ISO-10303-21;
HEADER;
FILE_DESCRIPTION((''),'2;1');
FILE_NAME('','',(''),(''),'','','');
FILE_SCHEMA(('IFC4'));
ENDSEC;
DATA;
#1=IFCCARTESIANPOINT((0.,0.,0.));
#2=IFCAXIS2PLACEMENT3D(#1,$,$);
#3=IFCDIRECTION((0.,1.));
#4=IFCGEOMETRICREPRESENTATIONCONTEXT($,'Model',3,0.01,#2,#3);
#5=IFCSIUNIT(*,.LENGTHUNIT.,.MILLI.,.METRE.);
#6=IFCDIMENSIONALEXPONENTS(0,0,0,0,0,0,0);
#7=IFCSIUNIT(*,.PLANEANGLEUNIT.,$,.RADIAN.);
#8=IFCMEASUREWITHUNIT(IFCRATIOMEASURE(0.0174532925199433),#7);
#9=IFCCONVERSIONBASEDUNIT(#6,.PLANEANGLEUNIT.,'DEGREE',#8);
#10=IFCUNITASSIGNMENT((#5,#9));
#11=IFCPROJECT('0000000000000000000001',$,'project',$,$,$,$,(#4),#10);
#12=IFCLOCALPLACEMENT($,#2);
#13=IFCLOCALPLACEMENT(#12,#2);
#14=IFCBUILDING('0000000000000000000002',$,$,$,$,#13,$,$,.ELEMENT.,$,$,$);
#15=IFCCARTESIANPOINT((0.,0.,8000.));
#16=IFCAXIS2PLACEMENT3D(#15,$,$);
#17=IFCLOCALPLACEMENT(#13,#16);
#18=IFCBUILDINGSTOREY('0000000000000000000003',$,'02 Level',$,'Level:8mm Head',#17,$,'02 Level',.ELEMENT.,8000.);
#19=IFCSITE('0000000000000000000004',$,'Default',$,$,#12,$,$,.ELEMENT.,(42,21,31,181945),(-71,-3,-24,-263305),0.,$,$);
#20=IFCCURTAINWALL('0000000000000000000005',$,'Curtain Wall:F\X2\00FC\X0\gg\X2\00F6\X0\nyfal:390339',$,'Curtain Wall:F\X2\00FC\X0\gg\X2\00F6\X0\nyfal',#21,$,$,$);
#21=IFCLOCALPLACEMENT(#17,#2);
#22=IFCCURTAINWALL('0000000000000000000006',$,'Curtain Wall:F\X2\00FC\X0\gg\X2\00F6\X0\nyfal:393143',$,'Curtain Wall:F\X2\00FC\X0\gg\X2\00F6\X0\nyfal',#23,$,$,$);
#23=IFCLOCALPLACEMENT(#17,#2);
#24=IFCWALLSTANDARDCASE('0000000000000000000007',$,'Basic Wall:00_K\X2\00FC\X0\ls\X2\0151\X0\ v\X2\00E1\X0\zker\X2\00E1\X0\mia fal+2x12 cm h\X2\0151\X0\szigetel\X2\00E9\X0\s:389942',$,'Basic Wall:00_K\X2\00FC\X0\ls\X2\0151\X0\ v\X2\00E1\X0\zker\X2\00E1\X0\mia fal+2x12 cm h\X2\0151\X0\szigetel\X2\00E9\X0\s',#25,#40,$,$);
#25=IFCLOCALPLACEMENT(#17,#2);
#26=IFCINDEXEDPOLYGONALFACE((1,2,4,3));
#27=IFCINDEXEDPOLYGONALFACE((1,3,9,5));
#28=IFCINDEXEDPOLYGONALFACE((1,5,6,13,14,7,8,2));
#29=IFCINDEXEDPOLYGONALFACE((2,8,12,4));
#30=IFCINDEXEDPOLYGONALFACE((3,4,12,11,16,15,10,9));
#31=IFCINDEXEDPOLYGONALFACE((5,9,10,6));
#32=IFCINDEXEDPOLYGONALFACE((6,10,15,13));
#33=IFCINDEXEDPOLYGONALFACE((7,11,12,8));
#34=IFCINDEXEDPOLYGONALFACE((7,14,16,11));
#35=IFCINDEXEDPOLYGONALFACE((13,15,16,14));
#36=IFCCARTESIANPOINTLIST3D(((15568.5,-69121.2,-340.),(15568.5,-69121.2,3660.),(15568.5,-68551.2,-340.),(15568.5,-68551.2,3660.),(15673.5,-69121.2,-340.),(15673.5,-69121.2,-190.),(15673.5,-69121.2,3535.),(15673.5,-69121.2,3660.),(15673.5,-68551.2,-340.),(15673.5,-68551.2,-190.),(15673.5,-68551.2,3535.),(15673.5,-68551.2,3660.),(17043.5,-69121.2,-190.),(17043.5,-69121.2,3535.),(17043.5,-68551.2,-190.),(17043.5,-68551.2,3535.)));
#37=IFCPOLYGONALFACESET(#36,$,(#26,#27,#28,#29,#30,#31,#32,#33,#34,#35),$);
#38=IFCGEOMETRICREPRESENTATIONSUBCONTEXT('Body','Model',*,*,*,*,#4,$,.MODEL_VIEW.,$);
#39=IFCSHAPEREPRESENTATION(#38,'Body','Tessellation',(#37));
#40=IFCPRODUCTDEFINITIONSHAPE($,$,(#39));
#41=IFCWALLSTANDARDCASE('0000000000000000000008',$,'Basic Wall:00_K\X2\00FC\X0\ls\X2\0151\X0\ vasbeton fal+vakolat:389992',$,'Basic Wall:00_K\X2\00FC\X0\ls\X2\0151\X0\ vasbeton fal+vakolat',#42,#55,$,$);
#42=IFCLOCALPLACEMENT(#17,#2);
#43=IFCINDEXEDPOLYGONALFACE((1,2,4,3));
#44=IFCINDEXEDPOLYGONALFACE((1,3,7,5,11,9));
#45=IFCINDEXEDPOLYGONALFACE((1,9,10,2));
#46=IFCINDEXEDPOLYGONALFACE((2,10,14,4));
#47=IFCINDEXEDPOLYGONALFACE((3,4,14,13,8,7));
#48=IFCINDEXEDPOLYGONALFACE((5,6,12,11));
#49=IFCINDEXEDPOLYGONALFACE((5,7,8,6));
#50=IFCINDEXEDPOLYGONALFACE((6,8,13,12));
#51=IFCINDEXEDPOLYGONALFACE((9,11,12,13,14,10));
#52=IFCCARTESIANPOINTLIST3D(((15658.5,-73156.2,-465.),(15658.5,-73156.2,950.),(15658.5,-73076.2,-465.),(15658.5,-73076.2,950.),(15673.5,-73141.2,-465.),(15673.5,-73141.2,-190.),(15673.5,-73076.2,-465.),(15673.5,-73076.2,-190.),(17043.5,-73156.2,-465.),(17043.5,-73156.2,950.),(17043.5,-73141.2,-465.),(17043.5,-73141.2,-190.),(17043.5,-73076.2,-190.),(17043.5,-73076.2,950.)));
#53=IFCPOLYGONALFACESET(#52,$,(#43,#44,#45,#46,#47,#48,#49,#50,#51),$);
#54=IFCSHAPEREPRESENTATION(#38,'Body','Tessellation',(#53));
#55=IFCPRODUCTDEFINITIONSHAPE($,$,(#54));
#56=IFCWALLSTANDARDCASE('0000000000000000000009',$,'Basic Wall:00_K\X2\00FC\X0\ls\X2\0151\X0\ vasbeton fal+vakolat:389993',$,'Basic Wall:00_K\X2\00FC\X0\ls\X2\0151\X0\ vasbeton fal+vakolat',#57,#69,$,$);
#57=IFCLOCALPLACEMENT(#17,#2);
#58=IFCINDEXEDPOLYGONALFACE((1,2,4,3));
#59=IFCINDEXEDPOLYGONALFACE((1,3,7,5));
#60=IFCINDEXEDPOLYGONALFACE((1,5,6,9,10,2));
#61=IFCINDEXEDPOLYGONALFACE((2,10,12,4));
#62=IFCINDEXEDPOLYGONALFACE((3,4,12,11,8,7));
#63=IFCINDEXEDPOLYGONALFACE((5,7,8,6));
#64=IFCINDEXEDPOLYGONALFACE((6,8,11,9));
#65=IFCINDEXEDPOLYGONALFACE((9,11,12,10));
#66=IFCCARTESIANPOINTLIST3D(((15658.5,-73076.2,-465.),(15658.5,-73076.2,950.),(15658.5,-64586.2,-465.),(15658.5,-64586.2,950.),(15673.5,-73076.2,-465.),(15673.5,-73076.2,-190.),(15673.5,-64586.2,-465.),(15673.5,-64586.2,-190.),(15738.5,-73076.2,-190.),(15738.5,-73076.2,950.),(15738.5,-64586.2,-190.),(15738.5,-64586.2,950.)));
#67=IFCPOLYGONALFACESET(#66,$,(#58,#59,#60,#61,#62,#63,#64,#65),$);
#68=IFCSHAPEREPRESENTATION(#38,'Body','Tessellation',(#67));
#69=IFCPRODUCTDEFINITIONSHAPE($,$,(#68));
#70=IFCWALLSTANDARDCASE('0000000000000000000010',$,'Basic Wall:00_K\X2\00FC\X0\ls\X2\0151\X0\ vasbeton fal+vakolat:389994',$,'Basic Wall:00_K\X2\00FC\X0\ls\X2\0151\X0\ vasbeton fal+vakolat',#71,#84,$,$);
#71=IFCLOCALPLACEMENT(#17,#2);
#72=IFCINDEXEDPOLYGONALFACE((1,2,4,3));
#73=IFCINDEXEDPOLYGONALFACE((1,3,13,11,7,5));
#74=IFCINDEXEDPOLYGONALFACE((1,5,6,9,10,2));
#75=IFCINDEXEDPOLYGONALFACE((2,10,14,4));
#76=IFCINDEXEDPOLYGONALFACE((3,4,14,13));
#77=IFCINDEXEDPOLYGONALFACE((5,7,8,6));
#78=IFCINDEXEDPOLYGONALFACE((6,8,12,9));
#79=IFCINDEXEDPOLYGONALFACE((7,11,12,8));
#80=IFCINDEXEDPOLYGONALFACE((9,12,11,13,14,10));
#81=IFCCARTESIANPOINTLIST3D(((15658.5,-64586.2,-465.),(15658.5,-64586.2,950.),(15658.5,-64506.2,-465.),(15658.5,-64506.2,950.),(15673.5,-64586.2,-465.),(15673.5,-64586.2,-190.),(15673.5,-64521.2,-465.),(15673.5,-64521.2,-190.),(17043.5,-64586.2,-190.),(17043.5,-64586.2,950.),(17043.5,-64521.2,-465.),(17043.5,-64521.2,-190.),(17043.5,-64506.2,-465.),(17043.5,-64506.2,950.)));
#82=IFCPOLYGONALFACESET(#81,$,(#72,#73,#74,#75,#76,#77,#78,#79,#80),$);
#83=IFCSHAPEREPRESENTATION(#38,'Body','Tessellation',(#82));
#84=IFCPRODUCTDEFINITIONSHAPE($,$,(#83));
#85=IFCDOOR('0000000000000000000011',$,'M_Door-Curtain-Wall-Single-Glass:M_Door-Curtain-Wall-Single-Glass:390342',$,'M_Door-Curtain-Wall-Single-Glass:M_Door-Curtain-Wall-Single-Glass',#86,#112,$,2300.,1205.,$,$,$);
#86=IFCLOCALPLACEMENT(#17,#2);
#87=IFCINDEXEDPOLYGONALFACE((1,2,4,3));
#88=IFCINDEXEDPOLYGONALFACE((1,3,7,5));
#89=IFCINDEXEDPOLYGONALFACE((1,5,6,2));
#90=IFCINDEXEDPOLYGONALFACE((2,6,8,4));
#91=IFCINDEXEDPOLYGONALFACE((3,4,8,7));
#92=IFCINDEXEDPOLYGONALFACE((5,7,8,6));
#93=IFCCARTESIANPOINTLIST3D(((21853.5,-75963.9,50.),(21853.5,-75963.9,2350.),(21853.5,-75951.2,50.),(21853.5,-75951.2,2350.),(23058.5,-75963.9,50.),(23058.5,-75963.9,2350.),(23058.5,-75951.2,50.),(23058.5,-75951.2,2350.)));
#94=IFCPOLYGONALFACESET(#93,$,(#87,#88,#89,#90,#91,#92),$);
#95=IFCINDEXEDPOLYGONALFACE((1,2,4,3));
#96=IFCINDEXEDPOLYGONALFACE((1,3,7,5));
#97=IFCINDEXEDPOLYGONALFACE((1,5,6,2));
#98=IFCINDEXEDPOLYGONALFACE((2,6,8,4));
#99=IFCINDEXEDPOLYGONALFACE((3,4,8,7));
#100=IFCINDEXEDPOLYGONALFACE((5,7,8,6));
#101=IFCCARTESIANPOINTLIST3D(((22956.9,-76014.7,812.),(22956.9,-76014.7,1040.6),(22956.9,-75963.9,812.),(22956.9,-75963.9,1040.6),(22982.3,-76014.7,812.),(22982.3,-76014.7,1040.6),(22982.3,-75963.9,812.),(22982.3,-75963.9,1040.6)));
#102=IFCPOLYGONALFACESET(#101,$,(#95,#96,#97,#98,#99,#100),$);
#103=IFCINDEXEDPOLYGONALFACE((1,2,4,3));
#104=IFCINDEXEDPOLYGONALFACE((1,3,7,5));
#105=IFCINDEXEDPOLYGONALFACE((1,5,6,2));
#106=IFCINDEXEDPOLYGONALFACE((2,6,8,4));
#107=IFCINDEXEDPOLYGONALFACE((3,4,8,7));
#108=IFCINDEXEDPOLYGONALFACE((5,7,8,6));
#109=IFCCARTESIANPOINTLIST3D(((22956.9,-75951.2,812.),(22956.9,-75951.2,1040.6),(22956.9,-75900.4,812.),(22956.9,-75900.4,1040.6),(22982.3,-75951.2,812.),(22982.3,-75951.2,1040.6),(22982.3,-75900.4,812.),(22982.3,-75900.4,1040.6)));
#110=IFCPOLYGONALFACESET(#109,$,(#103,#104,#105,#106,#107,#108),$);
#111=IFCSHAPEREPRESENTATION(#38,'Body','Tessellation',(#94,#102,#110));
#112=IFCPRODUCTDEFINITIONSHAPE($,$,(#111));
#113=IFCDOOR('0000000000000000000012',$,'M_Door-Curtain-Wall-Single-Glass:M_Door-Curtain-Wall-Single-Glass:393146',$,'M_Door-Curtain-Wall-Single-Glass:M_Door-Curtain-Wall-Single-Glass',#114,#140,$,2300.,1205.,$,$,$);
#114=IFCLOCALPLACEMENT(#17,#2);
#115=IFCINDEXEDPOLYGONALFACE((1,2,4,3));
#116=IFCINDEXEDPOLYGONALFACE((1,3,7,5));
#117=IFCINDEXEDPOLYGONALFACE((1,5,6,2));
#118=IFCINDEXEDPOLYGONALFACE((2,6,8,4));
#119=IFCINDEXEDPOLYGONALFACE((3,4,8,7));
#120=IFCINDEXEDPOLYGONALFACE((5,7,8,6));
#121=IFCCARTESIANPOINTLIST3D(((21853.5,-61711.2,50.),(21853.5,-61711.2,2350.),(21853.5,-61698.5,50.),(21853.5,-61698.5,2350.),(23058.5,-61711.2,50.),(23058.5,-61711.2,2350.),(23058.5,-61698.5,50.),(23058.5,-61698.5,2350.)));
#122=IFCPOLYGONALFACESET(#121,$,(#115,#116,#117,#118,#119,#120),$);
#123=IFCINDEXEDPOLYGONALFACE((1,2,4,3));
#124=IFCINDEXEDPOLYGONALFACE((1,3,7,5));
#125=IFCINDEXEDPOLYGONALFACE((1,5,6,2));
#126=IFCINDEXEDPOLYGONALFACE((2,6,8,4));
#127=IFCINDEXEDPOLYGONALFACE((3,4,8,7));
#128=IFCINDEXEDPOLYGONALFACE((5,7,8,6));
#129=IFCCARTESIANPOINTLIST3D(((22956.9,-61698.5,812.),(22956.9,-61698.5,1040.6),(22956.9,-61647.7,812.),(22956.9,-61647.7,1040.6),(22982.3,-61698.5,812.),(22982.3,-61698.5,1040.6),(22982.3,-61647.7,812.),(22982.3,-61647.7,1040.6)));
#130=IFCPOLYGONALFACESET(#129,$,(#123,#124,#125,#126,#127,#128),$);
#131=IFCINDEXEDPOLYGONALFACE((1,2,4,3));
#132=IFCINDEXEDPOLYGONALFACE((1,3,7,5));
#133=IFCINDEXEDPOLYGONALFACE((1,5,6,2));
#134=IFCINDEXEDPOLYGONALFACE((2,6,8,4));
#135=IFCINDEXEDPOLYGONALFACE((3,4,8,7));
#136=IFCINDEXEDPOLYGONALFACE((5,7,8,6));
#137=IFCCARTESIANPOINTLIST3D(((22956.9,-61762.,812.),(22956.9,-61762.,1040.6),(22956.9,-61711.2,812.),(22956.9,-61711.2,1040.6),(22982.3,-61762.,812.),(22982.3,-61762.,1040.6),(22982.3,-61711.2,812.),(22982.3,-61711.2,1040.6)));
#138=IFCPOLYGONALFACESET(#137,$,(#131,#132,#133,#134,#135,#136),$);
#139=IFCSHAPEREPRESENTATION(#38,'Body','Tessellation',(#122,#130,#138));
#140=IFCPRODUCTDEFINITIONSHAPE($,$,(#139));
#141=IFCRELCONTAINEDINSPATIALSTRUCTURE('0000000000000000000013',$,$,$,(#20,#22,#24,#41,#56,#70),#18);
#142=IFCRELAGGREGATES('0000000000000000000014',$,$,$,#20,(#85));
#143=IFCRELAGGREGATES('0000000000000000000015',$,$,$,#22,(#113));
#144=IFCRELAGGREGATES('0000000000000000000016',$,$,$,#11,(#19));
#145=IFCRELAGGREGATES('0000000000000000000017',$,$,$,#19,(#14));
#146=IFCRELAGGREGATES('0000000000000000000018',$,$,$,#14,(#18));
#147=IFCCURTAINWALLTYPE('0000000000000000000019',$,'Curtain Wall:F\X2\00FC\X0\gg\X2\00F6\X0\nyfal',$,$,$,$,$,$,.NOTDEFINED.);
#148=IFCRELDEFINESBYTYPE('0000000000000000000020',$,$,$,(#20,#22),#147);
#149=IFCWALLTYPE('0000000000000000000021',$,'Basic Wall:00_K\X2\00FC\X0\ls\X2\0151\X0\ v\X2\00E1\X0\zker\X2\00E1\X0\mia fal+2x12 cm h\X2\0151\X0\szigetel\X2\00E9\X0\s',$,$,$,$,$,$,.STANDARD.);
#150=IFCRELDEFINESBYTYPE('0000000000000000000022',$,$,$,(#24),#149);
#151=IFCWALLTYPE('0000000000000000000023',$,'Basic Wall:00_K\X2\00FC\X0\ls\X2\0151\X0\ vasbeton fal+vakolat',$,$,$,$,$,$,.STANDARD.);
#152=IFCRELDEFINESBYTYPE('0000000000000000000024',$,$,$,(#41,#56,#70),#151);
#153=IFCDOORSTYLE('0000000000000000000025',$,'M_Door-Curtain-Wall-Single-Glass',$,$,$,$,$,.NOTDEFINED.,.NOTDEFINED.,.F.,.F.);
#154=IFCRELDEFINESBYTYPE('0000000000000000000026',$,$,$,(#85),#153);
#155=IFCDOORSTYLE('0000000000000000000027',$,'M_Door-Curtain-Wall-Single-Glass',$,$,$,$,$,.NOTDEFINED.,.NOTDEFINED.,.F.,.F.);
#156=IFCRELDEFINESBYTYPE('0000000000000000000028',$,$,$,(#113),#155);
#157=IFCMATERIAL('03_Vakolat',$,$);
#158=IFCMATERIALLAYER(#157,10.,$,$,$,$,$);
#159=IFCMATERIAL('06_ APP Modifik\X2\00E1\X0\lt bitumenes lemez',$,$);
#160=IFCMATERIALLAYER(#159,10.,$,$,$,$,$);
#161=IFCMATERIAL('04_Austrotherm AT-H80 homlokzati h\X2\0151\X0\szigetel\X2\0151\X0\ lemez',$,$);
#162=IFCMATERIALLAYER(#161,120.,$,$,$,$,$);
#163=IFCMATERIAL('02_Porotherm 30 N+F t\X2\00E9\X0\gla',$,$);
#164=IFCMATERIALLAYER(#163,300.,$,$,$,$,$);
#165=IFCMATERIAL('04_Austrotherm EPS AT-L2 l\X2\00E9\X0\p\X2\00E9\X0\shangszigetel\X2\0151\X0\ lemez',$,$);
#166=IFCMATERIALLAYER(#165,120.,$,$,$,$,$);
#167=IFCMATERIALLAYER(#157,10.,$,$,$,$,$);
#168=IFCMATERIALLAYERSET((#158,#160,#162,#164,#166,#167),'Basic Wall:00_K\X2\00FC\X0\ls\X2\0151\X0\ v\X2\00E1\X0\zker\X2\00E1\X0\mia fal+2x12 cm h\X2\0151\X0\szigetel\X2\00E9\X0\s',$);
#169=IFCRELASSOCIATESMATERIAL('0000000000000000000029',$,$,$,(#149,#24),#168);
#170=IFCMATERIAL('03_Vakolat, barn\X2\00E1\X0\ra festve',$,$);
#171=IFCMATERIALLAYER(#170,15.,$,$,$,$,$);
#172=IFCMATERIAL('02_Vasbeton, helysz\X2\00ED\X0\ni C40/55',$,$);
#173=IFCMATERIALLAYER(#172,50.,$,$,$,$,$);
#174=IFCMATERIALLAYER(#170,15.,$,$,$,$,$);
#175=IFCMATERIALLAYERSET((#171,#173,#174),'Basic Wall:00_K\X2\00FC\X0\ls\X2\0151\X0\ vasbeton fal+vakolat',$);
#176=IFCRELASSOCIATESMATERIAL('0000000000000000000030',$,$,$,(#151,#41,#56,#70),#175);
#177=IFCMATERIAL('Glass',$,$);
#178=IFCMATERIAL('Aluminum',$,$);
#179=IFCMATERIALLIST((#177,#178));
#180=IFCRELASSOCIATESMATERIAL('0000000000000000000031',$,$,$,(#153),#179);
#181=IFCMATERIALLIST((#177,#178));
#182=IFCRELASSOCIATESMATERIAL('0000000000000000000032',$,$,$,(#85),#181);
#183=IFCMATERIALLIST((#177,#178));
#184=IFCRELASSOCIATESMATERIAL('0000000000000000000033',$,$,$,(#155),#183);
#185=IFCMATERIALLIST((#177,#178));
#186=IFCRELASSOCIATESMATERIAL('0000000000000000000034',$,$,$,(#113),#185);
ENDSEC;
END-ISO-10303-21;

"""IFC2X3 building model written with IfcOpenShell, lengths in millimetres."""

from ifc_helpers import new_model, entity, si_unit, converted_unit, direction, frame, frame_2d, origin, origin_2d_with_axis, place, context, subcontext, project, spatial, polyline, rectangle, extrude, clip, bounded_halfspace, source, transform, mapped, material, material_list, layer, layer_set, layer_usage, type_object, type_shapes, element, aggregate, save


model = new_model("IFC2X3")

# Units and contexts
model_context = context("Model", 3, precision=0.01, world=origin(), true_north=direction((0.0, 1.0)))
body_context = subcontext(model_context, "Body", "Model", "MODEL_VIEW")
ifc_project = project(units=[si_unit("LENGTHUNIT", "METRE", prefix="MILLI"), converted_unit("PLANEANGLEUNIT", "DEGREE", entity("IfcRatioMeasure", 0.0174532925199433), si_unit("PLANEANGLEUNIT", "RADIAN"), dimensions=[0, 0, 0, 0, 0, 0, 0])], contexts=[model_context])

# Site, building, storey
site_placement = place(None, origin())
site = spatial("IfcSite", under=ifc_project, at=site_placement, Name="Default", CompositionType="ELEMENT", RefLatitude=(42, 21, 31, 181945), RefLongitude=(-71, -3, -24, -263305), RefElevation=0.0)
building_placement = place(site_placement, origin())
building = spatial("IfcBuilding", under=site, at=building_placement, CompositionType="ELEMENT")
storey_placement = place(building_placement, frame((0.0, 0.0, 8000.0)))
storey = spatial("IfcBuildingStorey", under=building, at=storey_placement, Name="02 Level", ObjectType="Level:8mm Head", LongName="02 Level", CompositionType="ELEMENT", Elevation=8000.0)

# Curtain walls
curtain_wall_type = type_object("IfcCurtainWallType", Name="Curtain Wall:Függönyfal", PredefinedType="NOTDEFINED")
curtain_wall_1_placement = place(storey_placement, frame((0.0, 0.0, -8000.0)))
curtain_wall_1 = element("IfcCurtainWall", 1, at=curtain_wall_1_placement, inside=storey, type_object=curtain_wall_type, Name="Curtain Wall:Függönyfal:390339", ObjectType="Curtain Wall:Függönyfal")
curtain_wall_2_placement = place(storey_placement, frame((0.0, 0.0, -8000.0)))
curtain_wall_2 = element("IfcCurtainWall", 2, at=curtain_wall_2_placement, inside=storey, type_object=curtain_wall_type, Name="Curtain Wall:Függönyfal:393143", ObjectType="Curtain Wall:Függönyfal")

# Shared definitions
ifc_material_1 = material(Name="03_Vakolat")
ifc_material_2 = material(Name="04_Austrotherm AT-H80 homlokzati hőszigetelő lemez")
ifc_material_3 = material(Name="02_Porotherm 30 N+F tégla")

# Walls
ifc_layer_1 = layer(ifc_material_1, 10.0)
ifc_material_4 = material(Name="06_ APP Modifikált bitumenes lemez")
ifc_layer_2 = layer(ifc_material_4, 10.0)
ifc_layer_3 = layer(ifc_material_2, 120.0)
ifc_layer_4 = layer(ifc_material_3, 300.0)
ifc_material_5 = material(Name="04_Austrotherm EPS AT-L2 lépéshangszigetelő lemez")
ifc_layer_5 = layer(ifc_material_5, 120.0)
ifc_layer_6 = layer(ifc_material_1, 10.0)
ifc_layer_set_1 = layer_set([ifc_layer_1, ifc_layer_2, ifc_layer_3, ifc_layer_4, ifc_layer_5, ifc_layer_6], Name="Basic Wall:00_Külső vázkerámia fal+2x12 cm hőszigetelés")
ifc_layer_usage_1 = layer_usage(ifc_layer_set_1, "AXIS2", "NEGATIVE", 285.0)
wall_type_1 = type_object("IfcWallType", Name="Basic Wall:00_Külső vázkerámia fal+2x12 cm hőszigetelés", PredefinedType="STANDARD", material=ifc_layer_set_1)
wall_1_placement = place(storey_placement, frame((17043.5, -68836.2, -340.0), z_axis=(0.0, 0.0, 1.0), x_axis=(-1.0, 0.0, 0.0)))
element("IfcWallStandardCase", 3, at=wall_1_placement, inside=storey, type_object=wall_type_1, material=ifc_layer_usage_1, Name="Basic Wall:00_Külső vázkerámia fal+2x12 cm hőszigetelés:389942", ObjectType="Basic Wall:00_Külső vázkerámia fal+2x12 cm hőszigetelés", context=body_context, shape_type="Clipping", body=[
    clip(clip(clip(clip(extrude(rectangle(XDim=1475.0, YDim=570.0, at=frame_2d((737.5, 0.0), x_axis=(-1.0, 0.0))), origin(), (0.0, 0.0, 1.0), 4000.0), bounded_halfspace(frame((1370.0, 285.0, 150.0)), True, frame((1370.0, 285.0, 150.0)), polyline([(0.0, 0.0), (-1370.0, 0.0), (-1370.0, -570.0), (0.0, -570.0), (0.0, 0.0)]))), bounded_halfspace(frame((1370.0, -285.0, 150.0), z_axis=(1.0, 0.0, 0.0), x_axis=(0.0, 0.0, 1.0)), True, frame((1370.0, -285.0, 150.0), z_axis=(1.0, 0.0, 0.0), x_axis=(0.0, 0.0, 1.0)), polyline([(0.0, 0.0), (-150.0, 0.0), (-150.0, -570.0), (0.0, -570.0), (0.0, 0.0)]))), bounded_halfspace(frame((1370.0, -285.0, 3875.0), z_axis=(0.0, 0.0, -1.0), x_axis=(-1.0, 0.0, 0.0)), True, frame((1370.0, -285.0, 3875.0), z_axis=(0.0, 0.0, -1.0), x_axis=(-1.0, 0.0, 0.0)), polyline([(0.0, 0.0), (1370.0, 0.0), (1370.0, 570.0), (0.0, 570.0), (0.0, 0.0)]))), bounded_halfspace(frame((1370.0, 285.0, 3875.0), z_axis=(1.0, 0.0, 0.0), x_axis=(0.0, 0.0, 1.0)), True, frame((1370.0, 285.0, 3875.0), z_axis=(1.0, 0.0, 0.0), x_axis=(0.0, 0.0, 1.0)), polyline([(0.0, 0.0), (125.0, 0.0), (125.0, 570.0), (0.0, 570.0), (0.0, 0.0)]))),
])
ifc_material_6 = material(Name="03_Vakolat, barnára festve")
ifc_layer_7 = layer(ifc_material_6, 15.0)
ifc_material_7 = material(Name="02_Vasbeton, helyszíni C40/55")
ifc_layer_8 = layer(ifc_material_7, 50.0)
ifc_layer_9 = layer(ifc_material_6, 15.0)
ifc_layer_set_2 = layer_set([ifc_layer_7, ifc_layer_8, ifc_layer_9], Name="Basic Wall:00_Külső vasbeton fal+vakolat")
ifc_layer_usage_2 = layer_usage(ifc_layer_set_2, "AXIS2", "NEGATIVE", 40.0)
wall_type_2 = type_object("IfcWallType", Name="Basic Wall:00_Külső vasbeton fal+vakolat", PredefinedType="STANDARD", material=ifc_layer_set_2)
wall_2_placement = place(storey_placement, frame((17043.5, -73116.2, -465.0), z_axis=(0.0, 0.0, 1.0), x_axis=(-1.0, 0.0, 0.0)))
element("IfcWallStandardCase", 4, at=wall_2_placement, inside=storey, type_object=wall_type_2, material=ifc_layer_usage_2, Name="Basic Wall:00_Külső vasbeton fal+vakolat:389992", ObjectType="Basic Wall:00_Külső vasbeton fal+vakolat", context=body_context, shape_type="Clipping", body=[
    clip(clip(clip(extrude(rectangle(XDim=1385.0, YDim=80.0, at=frame_2d((692.5, 0.0), x_axis=(-1.0, 0.0))), origin(), (0.0, 0.0, 1.0), 1415.0), bounded_halfspace(frame((1370.0, 25.0, 0.0), z_axis=(1.0, 0.0, 0.0), x_axis=(0.0, 0.0, 1.0)), True, frame((1370.0, 25.0, 0.0), z_axis=(1.0, 0.0, 0.0), x_axis=(0.0, 0.0, 1.0)), polyline([(0.0, 0.0), (125.0, 0.0), (275.0, 0.0), (275.0, 65.0), (0.0, 65.0), (0.0, 0.0)]))), bounded_halfspace(frame((1370.0, 25.0, 0.0), z_axis=(0.0, 1.0, 0.0), x_axis=(0.0, 0.0, 1.0)), True, frame((1370.0, 25.0, 0.0), z_axis=(0.0, 1.0, 0.0), x_axis=(0.0, 0.0, 1.0)), polyline([(0.0, 0.0), (0.0, -1370.0), (125.0, -1370.0), (275.0, -1370.0), (275.0, 0.0), (125.0, 0.0), (0.0, 0.0)]))), bounded_halfspace(frame((1370.0, 25.0, 275.0)), True, frame((1370.0, 25.0, 275.0)), polyline([(0.0, 0.0), (-1370.0, 0.0), (-1370.0, -65.0), (-65.0, -65.0), (0.0, -65.0), (0.0, 0.0)]))),
])
ifc_layer_usage_3 = layer_usage(ifc_layer_set_2, "AXIS2", "NEGATIVE", 40.0)
wall_3_placement = place(storey_placement, frame((15698.5, -73076.2, -465.0), z_axis=(0.0, 0.0, 1.0), x_axis=(0.0, 1.0, 0.0)))
element("IfcWallStandardCase", 5, at=wall_3_placement, inside=storey, type_object=wall_type_2, material=ifc_layer_usage_3, Name="Basic Wall:00_Külső vasbeton fal+vakolat:389993", ObjectType="Basic Wall:00_Külső vasbeton fal+vakolat", context=body_context, shape_type="Clipping", body=[
    clip(clip(extrude(rectangle(XDim=8490.0, YDim=80.0, at=frame_2d((4245.0, 0.0), x_axis=(-1.0, 0.0))), origin(), (0.0, 0.0, 1.0), 1415.0), bounded_halfspace(frame((0.0, 25.0, 0.0), z_axis=(0.0, 1.0, 0.0), x_axis=(0.0, 0.0, 1.0)), True, frame((0.0, 25.0, 0.0), z_axis=(0.0, 1.0, 0.0), x_axis=(0.0, 0.0, 1.0)), polyline([(0.0, 0.0), (125.0, 0.0), (275.0, 0.0), (275.0, 8490.0), (125.0, 8490.0), (0.0, 8490.0), (0.0, 0.0)]))), bounded_halfspace(frame((0.0, 25.0, 275.0), z_axis=(0.0, 0.0, 1.0), x_axis=(0.0, 1.0, 0.0)), True, frame((0.0, 25.0, 275.0), z_axis=(0.0, 0.0, 1.0), x_axis=(0.0, 1.0, 0.0)), polyline([(0.0, 0.0), (-65.0, 0.0), (-65.0, -8490.0), (0.0, -8490.0), (0.0, 0.0)]))),
])
ifc_layer_usage_4 = layer_usage(ifc_layer_set_2, "AXIS2", "POSITIVE", -40.0)
wall_4_placement = place(storey_placement, frame((17043.5, -64546.2, -465.0), z_axis=(0.0, 0.0, 1.0), x_axis=(-1.0, 0.0, 0.0)))
element("IfcWallStandardCase", 6, at=wall_4_placement, inside=storey, type_object=wall_type_2, material=ifc_layer_usage_4, Name="Basic Wall:00_Külső vasbeton fal+vakolat:389994", ObjectType="Basic Wall:00_Külső vasbeton fal+vakolat", context=body_context, shape_type="Clipping", body=[
    clip(clip(clip(extrude(rectangle(XDim=1385.0, YDim=80.0, at=frame_2d((692.5, 0.0), x_axis=(-1.0, 0.0))), origin(), (0.0, 0.0, 1.0), 1415.0), bounded_halfspace(frame((1370.0, -25.0, 275.0), z_axis=(1.0, 0.0, 0.0), x_axis=(0.0, 0.0, 1.0)), True, frame((1370.0, -25.0, 275.0), z_axis=(1.0, 0.0, 0.0), x_axis=(0.0, 0.0, 1.0)), polyline([(0.0, 0.0), (-150.0, 0.0), (-275.0, 0.0), (-275.0, -65.0), (0.0, -65.0), (0.0, 0.0)]))), bounded_halfspace(frame((1370.0, -25.0, 275.0), z_axis=(0.0, -1.0, 0.0), x_axis=(0.0, 0.0, 1.0)), True, frame((1370.0, -25.0, 275.0), z_axis=(0.0, -1.0, 0.0), x_axis=(0.0, 0.0, 1.0)), polyline([(0.0, 0.0), (0.0, 1370.0), (-150.0, 1370.0), (-275.0, 1370.0), (-275.0, 0.0), (-150.0, 0.0), (0.0, 0.0)]))), bounded_halfspace(frame((1370.0, 40.0, 275.0)), True, frame((1370.0, 40.0, 275.0)), polyline([(0.0, 0.0), (-65.0, 0.0), (-1370.0, 0.0), (-1370.0, -65.0), (0.0, -65.0), (0.0, 0.0)]))),
])

# Doors
ifc_material_8 = material(Name="Glass")
ifc_material_9 = material(Name="Aluminum")
ifc_material_list_1 = material_list([ifc_material_8, ifc_material_9])
ifc_material_list_2 = material_list([ifc_material_8, ifc_material_9])
door_style_1 = type_object("IfcDoorStyle", Name="M_Door-Curtain-Wall-Single-Glass", ConstructionType="NOTDEFINED", OperationType="NOTDEFINED", ParameterTakesPrecedence=False, Sizeable=False, material=ifc_material_list_2)
shared_shape_1 = source(origin(), body_context, "Body", "SweptSolid", [
    extrude(rectangle(XDim=12.7, YDim=1205.0, at=origin_2d_with_axis()), frame((0.0, 6.3, 0.0), z_axis=(0.0, 0.0, 1.0), x_axis=(0.0, 1.0, 0.0)), (0.0, 0.0, 1.0), 2300.0),
    extrude(rectangle(XDim=25.4, YDim=50.8, at=frame_2d((0.0, 0.0), x_axis=(1.0, 0.0))), frame((-513.6, 38.1, 762.0), z_axis=(0.0, 0.0, 1.0), x_axis=(-1.0, 0.0, 0.0)), (0.0, 0.0, 1.0), 228.6),
    extrude(rectangle(XDim=25.4, YDim=50.8, at=frame_2d((0.0, 0.0), x_axis=(1.0, 0.0))), frame((-513.6, -25.4, 762.0)), (0.0, 0.0, 1.0), 228.6),
])
type_shapes(door_style_1, [shared_shape_1])
door_1_placement = place(curtain_wall_1_placement, frame((22456.0, -75951.2, 8050.0), z_axis=(0.0, 0.0, 1.0), x_axis=(-1.0, 0.0, 0.0)))
door_1 = element("IfcDoor", 7, at=door_1_placement, type_object=door_style_1, material=ifc_material_list_1, Name="M_Door-Curtain-Wall-Single-Glass:M_Door-Curtain-Wall-Single-Glass:390342", ObjectType="M_Door-Curtain-Wall-Single-Glass:M_Door-Curtain-Wall-Single-Glass", OverallHeight=2300.0, OverallWidth=1205.0, context=body_context, shape_type="MappedRepresentation", body=[
    mapped(shared_shape_1, transform((0.0, 0.0, 0.0), scale=1.0)),
])
aggregate(curtain_wall_1, [door_1])
ifc_material_list_3 = material_list([ifc_material_8, ifc_material_9])
ifc_material_list_4 = material_list([ifc_material_8, ifc_material_9])
door_style_2 = type_object("IfcDoorStyle", Name="M_Door-Curtain-Wall-Single-Glass", ConstructionType="NOTDEFINED", OperationType="NOTDEFINED", ParameterTakesPrecedence=False, Sizeable=False, material=ifc_material_list_4)
shared_shape_2 = source(origin(), body_context, "Body", "SweptSolid", [
    extrude(rectangle(XDim=1205.0, YDim=12.7, at=origin_2d_with_axis()), frame((0.0, -6.3, 0.0), z_axis=(0.0, 0.0, 1.0), x_axis=(-1.0, 0.0, 0.0)), (0.0, 0.0, 1.0), 2300.0),
    extrude(rectangle(XDim=50.8, YDim=25.4, at=frame_2d((0.0, 0.0), x_axis=(1.0, 0.0))), frame((-513.6, -38.1, 762.0), z_axis=(0.0, 0.0, 1.0), x_axis=(0.0, 1.0, 0.0)), (0.0, 0.0, 1.0), 228.6),
    extrude(rectangle(XDim=50.8, YDim=25.4, at=frame_2d((0.0, 0.0), x_axis=(1.0, 0.0))), frame((-513.6, 25.4, 762.0), z_axis=(0.0, 0.0, 1.0), x_axis=(0.0, -1.0, 0.0)), (0.0, 0.0, 1.0), 228.6),
])
type_shapes(door_style_2, [shared_shape_2])
door_2_placement = place(curtain_wall_2_placement, frame((22456.0, -61711.2, 8050.0), z_axis=(0.0, 0.0, 1.0), x_axis=(-1.0, 0.0, 0.0)))
door_2 = element("IfcDoor", 8, at=door_2_placement, type_object=door_style_2, material=ifc_material_list_3, Name="M_Door-Curtain-Wall-Single-Glass:M_Door-Curtain-Wall-Single-Glass:393146", ObjectType="M_Door-Curtain-Wall-Single-Glass:M_Door-Curtain-Wall-Single-Glass", OverallHeight=2300.0, OverallWidth=1205.0, context=body_context, shape_type="MappedRepresentation", body=[
    mapped(shared_shape_2, transform((0.0, 0.0, 0.0), scale=1.0)),
])
aggregate(curtain_wall_2, [door_2])

save(model, "model.ifc")
